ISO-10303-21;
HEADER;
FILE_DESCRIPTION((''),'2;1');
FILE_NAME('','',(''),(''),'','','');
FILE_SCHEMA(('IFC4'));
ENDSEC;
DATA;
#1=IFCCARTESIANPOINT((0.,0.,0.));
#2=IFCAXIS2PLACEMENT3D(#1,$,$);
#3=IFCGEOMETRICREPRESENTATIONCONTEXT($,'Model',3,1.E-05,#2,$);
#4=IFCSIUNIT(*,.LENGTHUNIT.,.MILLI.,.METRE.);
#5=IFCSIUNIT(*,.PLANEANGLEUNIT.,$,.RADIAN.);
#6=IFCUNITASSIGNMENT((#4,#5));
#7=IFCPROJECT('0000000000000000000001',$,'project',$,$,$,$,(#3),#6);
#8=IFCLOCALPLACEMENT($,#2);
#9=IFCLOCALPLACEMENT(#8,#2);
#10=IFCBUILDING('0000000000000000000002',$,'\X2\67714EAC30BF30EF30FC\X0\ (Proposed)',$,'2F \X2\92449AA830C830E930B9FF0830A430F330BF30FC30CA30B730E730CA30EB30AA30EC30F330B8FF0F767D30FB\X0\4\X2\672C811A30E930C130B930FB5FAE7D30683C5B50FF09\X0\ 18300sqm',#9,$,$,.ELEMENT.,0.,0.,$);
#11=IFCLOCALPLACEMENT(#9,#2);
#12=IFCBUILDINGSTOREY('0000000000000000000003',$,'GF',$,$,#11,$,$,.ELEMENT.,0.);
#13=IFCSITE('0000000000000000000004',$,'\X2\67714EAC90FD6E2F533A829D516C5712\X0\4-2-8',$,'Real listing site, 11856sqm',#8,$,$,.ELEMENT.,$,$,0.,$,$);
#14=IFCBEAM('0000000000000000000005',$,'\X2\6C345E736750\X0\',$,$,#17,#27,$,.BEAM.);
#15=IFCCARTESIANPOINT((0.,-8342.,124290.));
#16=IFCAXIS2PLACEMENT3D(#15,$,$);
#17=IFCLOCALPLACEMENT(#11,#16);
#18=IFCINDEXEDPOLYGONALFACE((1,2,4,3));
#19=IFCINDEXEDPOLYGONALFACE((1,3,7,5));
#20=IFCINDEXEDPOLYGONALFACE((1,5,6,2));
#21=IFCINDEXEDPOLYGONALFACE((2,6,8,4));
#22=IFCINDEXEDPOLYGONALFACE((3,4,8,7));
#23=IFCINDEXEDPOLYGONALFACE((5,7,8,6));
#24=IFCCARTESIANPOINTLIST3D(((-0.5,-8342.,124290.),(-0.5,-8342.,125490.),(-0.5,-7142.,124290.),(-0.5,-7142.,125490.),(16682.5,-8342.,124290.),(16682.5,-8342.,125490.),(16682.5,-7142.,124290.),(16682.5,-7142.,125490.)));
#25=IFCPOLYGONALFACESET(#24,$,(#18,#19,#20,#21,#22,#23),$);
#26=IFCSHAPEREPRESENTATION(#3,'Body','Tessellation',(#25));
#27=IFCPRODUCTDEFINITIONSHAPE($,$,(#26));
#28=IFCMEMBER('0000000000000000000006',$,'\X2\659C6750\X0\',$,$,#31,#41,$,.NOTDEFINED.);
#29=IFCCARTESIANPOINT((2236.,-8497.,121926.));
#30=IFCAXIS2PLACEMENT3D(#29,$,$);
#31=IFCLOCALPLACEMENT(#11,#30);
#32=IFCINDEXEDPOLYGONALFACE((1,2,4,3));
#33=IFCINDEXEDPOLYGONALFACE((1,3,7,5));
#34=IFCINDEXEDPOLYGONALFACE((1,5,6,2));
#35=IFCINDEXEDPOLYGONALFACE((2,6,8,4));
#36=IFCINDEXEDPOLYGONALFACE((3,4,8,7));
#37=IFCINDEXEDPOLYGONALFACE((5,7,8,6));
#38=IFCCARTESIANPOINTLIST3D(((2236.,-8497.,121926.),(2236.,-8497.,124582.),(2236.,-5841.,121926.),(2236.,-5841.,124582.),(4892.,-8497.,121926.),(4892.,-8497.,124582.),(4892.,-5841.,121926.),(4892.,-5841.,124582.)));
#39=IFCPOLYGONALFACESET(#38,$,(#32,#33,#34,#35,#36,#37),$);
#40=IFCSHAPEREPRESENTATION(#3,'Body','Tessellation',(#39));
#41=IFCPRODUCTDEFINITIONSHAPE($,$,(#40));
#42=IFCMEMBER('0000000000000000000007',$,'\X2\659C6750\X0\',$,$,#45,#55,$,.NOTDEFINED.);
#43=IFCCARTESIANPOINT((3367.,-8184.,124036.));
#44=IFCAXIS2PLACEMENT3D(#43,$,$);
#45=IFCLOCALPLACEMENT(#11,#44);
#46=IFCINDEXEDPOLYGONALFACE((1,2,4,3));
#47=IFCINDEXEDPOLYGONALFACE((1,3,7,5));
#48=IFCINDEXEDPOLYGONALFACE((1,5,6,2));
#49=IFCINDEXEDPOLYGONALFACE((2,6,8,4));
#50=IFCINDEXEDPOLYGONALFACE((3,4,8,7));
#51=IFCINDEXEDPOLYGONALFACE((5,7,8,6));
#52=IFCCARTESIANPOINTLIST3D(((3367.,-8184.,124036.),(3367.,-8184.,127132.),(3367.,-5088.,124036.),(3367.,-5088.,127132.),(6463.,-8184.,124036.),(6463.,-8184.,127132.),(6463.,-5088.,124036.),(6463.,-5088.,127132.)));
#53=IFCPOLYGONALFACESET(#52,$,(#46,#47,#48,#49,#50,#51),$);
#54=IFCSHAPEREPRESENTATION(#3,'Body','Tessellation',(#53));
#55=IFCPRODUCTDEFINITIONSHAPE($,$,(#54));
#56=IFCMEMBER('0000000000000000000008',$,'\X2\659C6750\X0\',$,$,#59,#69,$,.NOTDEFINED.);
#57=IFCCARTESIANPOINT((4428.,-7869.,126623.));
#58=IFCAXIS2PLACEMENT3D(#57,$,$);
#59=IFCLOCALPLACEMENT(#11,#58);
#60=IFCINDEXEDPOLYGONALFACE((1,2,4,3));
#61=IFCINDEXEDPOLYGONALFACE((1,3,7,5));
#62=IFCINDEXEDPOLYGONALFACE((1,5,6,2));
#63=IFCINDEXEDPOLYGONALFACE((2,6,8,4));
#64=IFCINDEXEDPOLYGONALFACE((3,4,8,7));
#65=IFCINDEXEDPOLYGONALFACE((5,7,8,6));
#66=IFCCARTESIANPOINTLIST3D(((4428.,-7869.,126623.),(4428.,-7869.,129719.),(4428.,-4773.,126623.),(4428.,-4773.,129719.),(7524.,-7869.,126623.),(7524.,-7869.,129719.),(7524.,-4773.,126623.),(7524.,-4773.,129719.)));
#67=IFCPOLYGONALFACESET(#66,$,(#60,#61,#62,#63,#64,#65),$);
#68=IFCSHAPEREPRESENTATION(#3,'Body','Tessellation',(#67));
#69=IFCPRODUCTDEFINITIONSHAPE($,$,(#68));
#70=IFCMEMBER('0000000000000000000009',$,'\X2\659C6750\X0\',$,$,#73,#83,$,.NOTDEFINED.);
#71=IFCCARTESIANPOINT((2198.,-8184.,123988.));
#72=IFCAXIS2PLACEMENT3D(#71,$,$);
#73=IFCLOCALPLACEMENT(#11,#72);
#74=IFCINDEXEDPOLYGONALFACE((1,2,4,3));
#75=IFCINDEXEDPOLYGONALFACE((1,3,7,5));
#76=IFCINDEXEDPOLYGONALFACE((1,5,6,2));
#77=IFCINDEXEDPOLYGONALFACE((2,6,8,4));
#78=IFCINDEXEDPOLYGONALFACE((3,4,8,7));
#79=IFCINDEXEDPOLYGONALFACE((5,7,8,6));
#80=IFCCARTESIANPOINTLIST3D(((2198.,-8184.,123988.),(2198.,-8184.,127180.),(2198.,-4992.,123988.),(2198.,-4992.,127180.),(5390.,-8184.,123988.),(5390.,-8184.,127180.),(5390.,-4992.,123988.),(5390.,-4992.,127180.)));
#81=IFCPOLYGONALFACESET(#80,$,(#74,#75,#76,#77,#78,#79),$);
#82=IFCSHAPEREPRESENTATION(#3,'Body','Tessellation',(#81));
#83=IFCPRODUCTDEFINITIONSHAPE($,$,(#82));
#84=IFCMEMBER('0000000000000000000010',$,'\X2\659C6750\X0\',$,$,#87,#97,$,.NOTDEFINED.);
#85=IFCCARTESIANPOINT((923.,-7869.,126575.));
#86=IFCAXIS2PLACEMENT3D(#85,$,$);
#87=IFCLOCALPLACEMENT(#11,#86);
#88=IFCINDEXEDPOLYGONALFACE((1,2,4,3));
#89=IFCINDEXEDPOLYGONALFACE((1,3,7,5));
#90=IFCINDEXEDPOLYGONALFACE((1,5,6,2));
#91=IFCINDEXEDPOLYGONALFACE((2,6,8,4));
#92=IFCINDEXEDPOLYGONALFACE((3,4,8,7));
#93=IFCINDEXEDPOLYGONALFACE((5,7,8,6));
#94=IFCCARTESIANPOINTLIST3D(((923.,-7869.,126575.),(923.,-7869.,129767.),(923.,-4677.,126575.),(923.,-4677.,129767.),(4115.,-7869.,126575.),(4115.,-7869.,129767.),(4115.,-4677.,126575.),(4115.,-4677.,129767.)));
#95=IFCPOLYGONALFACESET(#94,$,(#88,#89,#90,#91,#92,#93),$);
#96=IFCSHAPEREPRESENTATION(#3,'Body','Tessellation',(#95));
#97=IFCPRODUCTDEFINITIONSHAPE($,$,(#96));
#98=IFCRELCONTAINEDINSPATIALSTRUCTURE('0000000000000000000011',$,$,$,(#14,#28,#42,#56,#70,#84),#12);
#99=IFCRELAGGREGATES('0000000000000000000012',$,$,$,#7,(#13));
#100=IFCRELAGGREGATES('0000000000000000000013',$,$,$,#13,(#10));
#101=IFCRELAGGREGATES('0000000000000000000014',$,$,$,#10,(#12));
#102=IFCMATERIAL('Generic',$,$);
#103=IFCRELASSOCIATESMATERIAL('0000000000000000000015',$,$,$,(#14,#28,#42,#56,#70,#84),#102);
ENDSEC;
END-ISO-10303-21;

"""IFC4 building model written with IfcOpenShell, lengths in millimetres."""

from ifc_helpers import new_model, si_unit, frame, frame_2d, origin, place, context, project, spatial, rectangle, extrude, material, element, save


model = new_model("IFC4")

# Units and contexts
model_context = context("Model", 3, precision=1e-05, world=origin())
ifc_project = project(units=[si_unit("LENGTHUNIT", "METRE", prefix="MILLI"), si_unit("PLANEANGLEUNIT", "RADIAN")], contexts=[model_context])

# Site, building, storey
site_placement = place(None, origin())
site = spatial("IfcSite", under=ifc_project, at=site_placement, Name="東京都港区芝公園4-2-8", ObjectType="Real listing site, 11856sqm", CompositionType="ELEMENT", RefElevation=0.0)
building_placement = place(site_placement, origin())
building = spatial("IfcBuilding", under=site, at=building_placement, Name="東京タワー (Proposed)", ObjectType="2F 鉄骨トラス（インターナショナルオレンジ／白・4本脚ラチス・微細格子） 18300sqm", CompositionType="ELEMENT", ElevationOfRefHeight=0.0, ElevationOfTerrain=0.0)
storey_placement = place(building_placement, origin())
storey = spatial("IfcBuildingStorey", under=building, at=storey_placement, Name="GF", CompositionType="ELEMENT", Elevation=0.0)

# Shared definitions
ifc_material = material(Name="Generic")

# Beam
beam_placement = place(storey_placement, frame((0.0, -8342.0, 124290.0)))
element("IfcBeam", 1, at=beam_placement, inside=storey, material=ifc_material, Name="水平材", PredefinedType="BEAM", context=model_context, shape_type="SweptSolid", body=[
    extrude(rectangle(XDim=16683.0, YDim=1200.0, at=frame_2d((8341.0, 600.0))), frame((0.0, -8342.0, 124290.0)), (0.0, 0.0, 1.0), 1200.0),
])

# Members
member_1_placement = place(storey_placement, frame((2236.0, -8497.0, 121926.0)))
element("IfcMember", 2, at=member_1_placement, inside=storey, material=ifc_material, Name="斜材", PredefinedType="NOTDEFINED", context=model_context, shape_type="SweptSolid", body=[
    extrude(rectangle(XDim=2656.0, YDim=2656.0, at=frame_2d((1328.0, 1328.0))), frame((2236.0, -8497.0, 121926.0)), (0.0, 0.0, 1.0), 2656.0),
])
member_2_placement = place(storey_placement, frame((3367.0, -8184.0, 124036.0)))
element("IfcMember", 3, at=member_2_placement, inside=storey, material=ifc_material, Name="斜材", PredefinedType="NOTDEFINED", context=model_context, shape_type="SweptSolid", body=[
    extrude(rectangle(XDim=3096.0, YDim=3096.0, at=frame_2d((1548.0, 1548.0))), frame((3367.0, -8184.0, 124036.0)), (0.0, 0.0, 1.0), 3096.0),
])
member_3_placement = place(storey_placement, frame((4428.0, -7869.0, 126623.0)))
element("IfcMember", 4, at=member_3_placement, inside=storey, material=ifc_material, Name="斜材", PredefinedType="NOTDEFINED", context=model_context, shape_type="SweptSolid", body=[
    extrude(rectangle(XDim=3096.0, YDim=3096.0, at=frame_2d((1548.0, 1548.0))), frame((4428.0, -7869.0, 126623.0)), (0.0, 0.0, 1.0), 3096.0),
])
member_4_placement = place(storey_placement, frame((2198.0, -8184.0, 123988.0)))
element("IfcMember", 5, at=member_4_placement, inside=storey, material=ifc_material, Name="斜材", PredefinedType="NOTDEFINED", context=model_context, shape_type="SweptSolid", body=[
    extrude(rectangle(XDim=3192.0, YDim=3192.0, at=frame_2d((1596.0, 1596.0))), frame((2198.0, -8184.0, 123988.0)), (0.0, 0.0, 1.0), 3192.0),
])
member_5_placement = place(storey_placement, frame((923.0, -7869.0, 126575.0)))
element("IfcMember", 6, at=member_5_placement, inside=storey, material=ifc_material, Name="斜材", PredefinedType="NOTDEFINED", context=model_context, shape_type="SweptSolid", body=[
    extrude(rectangle(XDim=3192.0, YDim=3192.0, at=frame_2d((1596.0, 1596.0))), frame((923.0, -7869.0, 126575.0)), (0.0, 0.0, 1.0), 3192.0),
])

save(model, "model.ifc")
